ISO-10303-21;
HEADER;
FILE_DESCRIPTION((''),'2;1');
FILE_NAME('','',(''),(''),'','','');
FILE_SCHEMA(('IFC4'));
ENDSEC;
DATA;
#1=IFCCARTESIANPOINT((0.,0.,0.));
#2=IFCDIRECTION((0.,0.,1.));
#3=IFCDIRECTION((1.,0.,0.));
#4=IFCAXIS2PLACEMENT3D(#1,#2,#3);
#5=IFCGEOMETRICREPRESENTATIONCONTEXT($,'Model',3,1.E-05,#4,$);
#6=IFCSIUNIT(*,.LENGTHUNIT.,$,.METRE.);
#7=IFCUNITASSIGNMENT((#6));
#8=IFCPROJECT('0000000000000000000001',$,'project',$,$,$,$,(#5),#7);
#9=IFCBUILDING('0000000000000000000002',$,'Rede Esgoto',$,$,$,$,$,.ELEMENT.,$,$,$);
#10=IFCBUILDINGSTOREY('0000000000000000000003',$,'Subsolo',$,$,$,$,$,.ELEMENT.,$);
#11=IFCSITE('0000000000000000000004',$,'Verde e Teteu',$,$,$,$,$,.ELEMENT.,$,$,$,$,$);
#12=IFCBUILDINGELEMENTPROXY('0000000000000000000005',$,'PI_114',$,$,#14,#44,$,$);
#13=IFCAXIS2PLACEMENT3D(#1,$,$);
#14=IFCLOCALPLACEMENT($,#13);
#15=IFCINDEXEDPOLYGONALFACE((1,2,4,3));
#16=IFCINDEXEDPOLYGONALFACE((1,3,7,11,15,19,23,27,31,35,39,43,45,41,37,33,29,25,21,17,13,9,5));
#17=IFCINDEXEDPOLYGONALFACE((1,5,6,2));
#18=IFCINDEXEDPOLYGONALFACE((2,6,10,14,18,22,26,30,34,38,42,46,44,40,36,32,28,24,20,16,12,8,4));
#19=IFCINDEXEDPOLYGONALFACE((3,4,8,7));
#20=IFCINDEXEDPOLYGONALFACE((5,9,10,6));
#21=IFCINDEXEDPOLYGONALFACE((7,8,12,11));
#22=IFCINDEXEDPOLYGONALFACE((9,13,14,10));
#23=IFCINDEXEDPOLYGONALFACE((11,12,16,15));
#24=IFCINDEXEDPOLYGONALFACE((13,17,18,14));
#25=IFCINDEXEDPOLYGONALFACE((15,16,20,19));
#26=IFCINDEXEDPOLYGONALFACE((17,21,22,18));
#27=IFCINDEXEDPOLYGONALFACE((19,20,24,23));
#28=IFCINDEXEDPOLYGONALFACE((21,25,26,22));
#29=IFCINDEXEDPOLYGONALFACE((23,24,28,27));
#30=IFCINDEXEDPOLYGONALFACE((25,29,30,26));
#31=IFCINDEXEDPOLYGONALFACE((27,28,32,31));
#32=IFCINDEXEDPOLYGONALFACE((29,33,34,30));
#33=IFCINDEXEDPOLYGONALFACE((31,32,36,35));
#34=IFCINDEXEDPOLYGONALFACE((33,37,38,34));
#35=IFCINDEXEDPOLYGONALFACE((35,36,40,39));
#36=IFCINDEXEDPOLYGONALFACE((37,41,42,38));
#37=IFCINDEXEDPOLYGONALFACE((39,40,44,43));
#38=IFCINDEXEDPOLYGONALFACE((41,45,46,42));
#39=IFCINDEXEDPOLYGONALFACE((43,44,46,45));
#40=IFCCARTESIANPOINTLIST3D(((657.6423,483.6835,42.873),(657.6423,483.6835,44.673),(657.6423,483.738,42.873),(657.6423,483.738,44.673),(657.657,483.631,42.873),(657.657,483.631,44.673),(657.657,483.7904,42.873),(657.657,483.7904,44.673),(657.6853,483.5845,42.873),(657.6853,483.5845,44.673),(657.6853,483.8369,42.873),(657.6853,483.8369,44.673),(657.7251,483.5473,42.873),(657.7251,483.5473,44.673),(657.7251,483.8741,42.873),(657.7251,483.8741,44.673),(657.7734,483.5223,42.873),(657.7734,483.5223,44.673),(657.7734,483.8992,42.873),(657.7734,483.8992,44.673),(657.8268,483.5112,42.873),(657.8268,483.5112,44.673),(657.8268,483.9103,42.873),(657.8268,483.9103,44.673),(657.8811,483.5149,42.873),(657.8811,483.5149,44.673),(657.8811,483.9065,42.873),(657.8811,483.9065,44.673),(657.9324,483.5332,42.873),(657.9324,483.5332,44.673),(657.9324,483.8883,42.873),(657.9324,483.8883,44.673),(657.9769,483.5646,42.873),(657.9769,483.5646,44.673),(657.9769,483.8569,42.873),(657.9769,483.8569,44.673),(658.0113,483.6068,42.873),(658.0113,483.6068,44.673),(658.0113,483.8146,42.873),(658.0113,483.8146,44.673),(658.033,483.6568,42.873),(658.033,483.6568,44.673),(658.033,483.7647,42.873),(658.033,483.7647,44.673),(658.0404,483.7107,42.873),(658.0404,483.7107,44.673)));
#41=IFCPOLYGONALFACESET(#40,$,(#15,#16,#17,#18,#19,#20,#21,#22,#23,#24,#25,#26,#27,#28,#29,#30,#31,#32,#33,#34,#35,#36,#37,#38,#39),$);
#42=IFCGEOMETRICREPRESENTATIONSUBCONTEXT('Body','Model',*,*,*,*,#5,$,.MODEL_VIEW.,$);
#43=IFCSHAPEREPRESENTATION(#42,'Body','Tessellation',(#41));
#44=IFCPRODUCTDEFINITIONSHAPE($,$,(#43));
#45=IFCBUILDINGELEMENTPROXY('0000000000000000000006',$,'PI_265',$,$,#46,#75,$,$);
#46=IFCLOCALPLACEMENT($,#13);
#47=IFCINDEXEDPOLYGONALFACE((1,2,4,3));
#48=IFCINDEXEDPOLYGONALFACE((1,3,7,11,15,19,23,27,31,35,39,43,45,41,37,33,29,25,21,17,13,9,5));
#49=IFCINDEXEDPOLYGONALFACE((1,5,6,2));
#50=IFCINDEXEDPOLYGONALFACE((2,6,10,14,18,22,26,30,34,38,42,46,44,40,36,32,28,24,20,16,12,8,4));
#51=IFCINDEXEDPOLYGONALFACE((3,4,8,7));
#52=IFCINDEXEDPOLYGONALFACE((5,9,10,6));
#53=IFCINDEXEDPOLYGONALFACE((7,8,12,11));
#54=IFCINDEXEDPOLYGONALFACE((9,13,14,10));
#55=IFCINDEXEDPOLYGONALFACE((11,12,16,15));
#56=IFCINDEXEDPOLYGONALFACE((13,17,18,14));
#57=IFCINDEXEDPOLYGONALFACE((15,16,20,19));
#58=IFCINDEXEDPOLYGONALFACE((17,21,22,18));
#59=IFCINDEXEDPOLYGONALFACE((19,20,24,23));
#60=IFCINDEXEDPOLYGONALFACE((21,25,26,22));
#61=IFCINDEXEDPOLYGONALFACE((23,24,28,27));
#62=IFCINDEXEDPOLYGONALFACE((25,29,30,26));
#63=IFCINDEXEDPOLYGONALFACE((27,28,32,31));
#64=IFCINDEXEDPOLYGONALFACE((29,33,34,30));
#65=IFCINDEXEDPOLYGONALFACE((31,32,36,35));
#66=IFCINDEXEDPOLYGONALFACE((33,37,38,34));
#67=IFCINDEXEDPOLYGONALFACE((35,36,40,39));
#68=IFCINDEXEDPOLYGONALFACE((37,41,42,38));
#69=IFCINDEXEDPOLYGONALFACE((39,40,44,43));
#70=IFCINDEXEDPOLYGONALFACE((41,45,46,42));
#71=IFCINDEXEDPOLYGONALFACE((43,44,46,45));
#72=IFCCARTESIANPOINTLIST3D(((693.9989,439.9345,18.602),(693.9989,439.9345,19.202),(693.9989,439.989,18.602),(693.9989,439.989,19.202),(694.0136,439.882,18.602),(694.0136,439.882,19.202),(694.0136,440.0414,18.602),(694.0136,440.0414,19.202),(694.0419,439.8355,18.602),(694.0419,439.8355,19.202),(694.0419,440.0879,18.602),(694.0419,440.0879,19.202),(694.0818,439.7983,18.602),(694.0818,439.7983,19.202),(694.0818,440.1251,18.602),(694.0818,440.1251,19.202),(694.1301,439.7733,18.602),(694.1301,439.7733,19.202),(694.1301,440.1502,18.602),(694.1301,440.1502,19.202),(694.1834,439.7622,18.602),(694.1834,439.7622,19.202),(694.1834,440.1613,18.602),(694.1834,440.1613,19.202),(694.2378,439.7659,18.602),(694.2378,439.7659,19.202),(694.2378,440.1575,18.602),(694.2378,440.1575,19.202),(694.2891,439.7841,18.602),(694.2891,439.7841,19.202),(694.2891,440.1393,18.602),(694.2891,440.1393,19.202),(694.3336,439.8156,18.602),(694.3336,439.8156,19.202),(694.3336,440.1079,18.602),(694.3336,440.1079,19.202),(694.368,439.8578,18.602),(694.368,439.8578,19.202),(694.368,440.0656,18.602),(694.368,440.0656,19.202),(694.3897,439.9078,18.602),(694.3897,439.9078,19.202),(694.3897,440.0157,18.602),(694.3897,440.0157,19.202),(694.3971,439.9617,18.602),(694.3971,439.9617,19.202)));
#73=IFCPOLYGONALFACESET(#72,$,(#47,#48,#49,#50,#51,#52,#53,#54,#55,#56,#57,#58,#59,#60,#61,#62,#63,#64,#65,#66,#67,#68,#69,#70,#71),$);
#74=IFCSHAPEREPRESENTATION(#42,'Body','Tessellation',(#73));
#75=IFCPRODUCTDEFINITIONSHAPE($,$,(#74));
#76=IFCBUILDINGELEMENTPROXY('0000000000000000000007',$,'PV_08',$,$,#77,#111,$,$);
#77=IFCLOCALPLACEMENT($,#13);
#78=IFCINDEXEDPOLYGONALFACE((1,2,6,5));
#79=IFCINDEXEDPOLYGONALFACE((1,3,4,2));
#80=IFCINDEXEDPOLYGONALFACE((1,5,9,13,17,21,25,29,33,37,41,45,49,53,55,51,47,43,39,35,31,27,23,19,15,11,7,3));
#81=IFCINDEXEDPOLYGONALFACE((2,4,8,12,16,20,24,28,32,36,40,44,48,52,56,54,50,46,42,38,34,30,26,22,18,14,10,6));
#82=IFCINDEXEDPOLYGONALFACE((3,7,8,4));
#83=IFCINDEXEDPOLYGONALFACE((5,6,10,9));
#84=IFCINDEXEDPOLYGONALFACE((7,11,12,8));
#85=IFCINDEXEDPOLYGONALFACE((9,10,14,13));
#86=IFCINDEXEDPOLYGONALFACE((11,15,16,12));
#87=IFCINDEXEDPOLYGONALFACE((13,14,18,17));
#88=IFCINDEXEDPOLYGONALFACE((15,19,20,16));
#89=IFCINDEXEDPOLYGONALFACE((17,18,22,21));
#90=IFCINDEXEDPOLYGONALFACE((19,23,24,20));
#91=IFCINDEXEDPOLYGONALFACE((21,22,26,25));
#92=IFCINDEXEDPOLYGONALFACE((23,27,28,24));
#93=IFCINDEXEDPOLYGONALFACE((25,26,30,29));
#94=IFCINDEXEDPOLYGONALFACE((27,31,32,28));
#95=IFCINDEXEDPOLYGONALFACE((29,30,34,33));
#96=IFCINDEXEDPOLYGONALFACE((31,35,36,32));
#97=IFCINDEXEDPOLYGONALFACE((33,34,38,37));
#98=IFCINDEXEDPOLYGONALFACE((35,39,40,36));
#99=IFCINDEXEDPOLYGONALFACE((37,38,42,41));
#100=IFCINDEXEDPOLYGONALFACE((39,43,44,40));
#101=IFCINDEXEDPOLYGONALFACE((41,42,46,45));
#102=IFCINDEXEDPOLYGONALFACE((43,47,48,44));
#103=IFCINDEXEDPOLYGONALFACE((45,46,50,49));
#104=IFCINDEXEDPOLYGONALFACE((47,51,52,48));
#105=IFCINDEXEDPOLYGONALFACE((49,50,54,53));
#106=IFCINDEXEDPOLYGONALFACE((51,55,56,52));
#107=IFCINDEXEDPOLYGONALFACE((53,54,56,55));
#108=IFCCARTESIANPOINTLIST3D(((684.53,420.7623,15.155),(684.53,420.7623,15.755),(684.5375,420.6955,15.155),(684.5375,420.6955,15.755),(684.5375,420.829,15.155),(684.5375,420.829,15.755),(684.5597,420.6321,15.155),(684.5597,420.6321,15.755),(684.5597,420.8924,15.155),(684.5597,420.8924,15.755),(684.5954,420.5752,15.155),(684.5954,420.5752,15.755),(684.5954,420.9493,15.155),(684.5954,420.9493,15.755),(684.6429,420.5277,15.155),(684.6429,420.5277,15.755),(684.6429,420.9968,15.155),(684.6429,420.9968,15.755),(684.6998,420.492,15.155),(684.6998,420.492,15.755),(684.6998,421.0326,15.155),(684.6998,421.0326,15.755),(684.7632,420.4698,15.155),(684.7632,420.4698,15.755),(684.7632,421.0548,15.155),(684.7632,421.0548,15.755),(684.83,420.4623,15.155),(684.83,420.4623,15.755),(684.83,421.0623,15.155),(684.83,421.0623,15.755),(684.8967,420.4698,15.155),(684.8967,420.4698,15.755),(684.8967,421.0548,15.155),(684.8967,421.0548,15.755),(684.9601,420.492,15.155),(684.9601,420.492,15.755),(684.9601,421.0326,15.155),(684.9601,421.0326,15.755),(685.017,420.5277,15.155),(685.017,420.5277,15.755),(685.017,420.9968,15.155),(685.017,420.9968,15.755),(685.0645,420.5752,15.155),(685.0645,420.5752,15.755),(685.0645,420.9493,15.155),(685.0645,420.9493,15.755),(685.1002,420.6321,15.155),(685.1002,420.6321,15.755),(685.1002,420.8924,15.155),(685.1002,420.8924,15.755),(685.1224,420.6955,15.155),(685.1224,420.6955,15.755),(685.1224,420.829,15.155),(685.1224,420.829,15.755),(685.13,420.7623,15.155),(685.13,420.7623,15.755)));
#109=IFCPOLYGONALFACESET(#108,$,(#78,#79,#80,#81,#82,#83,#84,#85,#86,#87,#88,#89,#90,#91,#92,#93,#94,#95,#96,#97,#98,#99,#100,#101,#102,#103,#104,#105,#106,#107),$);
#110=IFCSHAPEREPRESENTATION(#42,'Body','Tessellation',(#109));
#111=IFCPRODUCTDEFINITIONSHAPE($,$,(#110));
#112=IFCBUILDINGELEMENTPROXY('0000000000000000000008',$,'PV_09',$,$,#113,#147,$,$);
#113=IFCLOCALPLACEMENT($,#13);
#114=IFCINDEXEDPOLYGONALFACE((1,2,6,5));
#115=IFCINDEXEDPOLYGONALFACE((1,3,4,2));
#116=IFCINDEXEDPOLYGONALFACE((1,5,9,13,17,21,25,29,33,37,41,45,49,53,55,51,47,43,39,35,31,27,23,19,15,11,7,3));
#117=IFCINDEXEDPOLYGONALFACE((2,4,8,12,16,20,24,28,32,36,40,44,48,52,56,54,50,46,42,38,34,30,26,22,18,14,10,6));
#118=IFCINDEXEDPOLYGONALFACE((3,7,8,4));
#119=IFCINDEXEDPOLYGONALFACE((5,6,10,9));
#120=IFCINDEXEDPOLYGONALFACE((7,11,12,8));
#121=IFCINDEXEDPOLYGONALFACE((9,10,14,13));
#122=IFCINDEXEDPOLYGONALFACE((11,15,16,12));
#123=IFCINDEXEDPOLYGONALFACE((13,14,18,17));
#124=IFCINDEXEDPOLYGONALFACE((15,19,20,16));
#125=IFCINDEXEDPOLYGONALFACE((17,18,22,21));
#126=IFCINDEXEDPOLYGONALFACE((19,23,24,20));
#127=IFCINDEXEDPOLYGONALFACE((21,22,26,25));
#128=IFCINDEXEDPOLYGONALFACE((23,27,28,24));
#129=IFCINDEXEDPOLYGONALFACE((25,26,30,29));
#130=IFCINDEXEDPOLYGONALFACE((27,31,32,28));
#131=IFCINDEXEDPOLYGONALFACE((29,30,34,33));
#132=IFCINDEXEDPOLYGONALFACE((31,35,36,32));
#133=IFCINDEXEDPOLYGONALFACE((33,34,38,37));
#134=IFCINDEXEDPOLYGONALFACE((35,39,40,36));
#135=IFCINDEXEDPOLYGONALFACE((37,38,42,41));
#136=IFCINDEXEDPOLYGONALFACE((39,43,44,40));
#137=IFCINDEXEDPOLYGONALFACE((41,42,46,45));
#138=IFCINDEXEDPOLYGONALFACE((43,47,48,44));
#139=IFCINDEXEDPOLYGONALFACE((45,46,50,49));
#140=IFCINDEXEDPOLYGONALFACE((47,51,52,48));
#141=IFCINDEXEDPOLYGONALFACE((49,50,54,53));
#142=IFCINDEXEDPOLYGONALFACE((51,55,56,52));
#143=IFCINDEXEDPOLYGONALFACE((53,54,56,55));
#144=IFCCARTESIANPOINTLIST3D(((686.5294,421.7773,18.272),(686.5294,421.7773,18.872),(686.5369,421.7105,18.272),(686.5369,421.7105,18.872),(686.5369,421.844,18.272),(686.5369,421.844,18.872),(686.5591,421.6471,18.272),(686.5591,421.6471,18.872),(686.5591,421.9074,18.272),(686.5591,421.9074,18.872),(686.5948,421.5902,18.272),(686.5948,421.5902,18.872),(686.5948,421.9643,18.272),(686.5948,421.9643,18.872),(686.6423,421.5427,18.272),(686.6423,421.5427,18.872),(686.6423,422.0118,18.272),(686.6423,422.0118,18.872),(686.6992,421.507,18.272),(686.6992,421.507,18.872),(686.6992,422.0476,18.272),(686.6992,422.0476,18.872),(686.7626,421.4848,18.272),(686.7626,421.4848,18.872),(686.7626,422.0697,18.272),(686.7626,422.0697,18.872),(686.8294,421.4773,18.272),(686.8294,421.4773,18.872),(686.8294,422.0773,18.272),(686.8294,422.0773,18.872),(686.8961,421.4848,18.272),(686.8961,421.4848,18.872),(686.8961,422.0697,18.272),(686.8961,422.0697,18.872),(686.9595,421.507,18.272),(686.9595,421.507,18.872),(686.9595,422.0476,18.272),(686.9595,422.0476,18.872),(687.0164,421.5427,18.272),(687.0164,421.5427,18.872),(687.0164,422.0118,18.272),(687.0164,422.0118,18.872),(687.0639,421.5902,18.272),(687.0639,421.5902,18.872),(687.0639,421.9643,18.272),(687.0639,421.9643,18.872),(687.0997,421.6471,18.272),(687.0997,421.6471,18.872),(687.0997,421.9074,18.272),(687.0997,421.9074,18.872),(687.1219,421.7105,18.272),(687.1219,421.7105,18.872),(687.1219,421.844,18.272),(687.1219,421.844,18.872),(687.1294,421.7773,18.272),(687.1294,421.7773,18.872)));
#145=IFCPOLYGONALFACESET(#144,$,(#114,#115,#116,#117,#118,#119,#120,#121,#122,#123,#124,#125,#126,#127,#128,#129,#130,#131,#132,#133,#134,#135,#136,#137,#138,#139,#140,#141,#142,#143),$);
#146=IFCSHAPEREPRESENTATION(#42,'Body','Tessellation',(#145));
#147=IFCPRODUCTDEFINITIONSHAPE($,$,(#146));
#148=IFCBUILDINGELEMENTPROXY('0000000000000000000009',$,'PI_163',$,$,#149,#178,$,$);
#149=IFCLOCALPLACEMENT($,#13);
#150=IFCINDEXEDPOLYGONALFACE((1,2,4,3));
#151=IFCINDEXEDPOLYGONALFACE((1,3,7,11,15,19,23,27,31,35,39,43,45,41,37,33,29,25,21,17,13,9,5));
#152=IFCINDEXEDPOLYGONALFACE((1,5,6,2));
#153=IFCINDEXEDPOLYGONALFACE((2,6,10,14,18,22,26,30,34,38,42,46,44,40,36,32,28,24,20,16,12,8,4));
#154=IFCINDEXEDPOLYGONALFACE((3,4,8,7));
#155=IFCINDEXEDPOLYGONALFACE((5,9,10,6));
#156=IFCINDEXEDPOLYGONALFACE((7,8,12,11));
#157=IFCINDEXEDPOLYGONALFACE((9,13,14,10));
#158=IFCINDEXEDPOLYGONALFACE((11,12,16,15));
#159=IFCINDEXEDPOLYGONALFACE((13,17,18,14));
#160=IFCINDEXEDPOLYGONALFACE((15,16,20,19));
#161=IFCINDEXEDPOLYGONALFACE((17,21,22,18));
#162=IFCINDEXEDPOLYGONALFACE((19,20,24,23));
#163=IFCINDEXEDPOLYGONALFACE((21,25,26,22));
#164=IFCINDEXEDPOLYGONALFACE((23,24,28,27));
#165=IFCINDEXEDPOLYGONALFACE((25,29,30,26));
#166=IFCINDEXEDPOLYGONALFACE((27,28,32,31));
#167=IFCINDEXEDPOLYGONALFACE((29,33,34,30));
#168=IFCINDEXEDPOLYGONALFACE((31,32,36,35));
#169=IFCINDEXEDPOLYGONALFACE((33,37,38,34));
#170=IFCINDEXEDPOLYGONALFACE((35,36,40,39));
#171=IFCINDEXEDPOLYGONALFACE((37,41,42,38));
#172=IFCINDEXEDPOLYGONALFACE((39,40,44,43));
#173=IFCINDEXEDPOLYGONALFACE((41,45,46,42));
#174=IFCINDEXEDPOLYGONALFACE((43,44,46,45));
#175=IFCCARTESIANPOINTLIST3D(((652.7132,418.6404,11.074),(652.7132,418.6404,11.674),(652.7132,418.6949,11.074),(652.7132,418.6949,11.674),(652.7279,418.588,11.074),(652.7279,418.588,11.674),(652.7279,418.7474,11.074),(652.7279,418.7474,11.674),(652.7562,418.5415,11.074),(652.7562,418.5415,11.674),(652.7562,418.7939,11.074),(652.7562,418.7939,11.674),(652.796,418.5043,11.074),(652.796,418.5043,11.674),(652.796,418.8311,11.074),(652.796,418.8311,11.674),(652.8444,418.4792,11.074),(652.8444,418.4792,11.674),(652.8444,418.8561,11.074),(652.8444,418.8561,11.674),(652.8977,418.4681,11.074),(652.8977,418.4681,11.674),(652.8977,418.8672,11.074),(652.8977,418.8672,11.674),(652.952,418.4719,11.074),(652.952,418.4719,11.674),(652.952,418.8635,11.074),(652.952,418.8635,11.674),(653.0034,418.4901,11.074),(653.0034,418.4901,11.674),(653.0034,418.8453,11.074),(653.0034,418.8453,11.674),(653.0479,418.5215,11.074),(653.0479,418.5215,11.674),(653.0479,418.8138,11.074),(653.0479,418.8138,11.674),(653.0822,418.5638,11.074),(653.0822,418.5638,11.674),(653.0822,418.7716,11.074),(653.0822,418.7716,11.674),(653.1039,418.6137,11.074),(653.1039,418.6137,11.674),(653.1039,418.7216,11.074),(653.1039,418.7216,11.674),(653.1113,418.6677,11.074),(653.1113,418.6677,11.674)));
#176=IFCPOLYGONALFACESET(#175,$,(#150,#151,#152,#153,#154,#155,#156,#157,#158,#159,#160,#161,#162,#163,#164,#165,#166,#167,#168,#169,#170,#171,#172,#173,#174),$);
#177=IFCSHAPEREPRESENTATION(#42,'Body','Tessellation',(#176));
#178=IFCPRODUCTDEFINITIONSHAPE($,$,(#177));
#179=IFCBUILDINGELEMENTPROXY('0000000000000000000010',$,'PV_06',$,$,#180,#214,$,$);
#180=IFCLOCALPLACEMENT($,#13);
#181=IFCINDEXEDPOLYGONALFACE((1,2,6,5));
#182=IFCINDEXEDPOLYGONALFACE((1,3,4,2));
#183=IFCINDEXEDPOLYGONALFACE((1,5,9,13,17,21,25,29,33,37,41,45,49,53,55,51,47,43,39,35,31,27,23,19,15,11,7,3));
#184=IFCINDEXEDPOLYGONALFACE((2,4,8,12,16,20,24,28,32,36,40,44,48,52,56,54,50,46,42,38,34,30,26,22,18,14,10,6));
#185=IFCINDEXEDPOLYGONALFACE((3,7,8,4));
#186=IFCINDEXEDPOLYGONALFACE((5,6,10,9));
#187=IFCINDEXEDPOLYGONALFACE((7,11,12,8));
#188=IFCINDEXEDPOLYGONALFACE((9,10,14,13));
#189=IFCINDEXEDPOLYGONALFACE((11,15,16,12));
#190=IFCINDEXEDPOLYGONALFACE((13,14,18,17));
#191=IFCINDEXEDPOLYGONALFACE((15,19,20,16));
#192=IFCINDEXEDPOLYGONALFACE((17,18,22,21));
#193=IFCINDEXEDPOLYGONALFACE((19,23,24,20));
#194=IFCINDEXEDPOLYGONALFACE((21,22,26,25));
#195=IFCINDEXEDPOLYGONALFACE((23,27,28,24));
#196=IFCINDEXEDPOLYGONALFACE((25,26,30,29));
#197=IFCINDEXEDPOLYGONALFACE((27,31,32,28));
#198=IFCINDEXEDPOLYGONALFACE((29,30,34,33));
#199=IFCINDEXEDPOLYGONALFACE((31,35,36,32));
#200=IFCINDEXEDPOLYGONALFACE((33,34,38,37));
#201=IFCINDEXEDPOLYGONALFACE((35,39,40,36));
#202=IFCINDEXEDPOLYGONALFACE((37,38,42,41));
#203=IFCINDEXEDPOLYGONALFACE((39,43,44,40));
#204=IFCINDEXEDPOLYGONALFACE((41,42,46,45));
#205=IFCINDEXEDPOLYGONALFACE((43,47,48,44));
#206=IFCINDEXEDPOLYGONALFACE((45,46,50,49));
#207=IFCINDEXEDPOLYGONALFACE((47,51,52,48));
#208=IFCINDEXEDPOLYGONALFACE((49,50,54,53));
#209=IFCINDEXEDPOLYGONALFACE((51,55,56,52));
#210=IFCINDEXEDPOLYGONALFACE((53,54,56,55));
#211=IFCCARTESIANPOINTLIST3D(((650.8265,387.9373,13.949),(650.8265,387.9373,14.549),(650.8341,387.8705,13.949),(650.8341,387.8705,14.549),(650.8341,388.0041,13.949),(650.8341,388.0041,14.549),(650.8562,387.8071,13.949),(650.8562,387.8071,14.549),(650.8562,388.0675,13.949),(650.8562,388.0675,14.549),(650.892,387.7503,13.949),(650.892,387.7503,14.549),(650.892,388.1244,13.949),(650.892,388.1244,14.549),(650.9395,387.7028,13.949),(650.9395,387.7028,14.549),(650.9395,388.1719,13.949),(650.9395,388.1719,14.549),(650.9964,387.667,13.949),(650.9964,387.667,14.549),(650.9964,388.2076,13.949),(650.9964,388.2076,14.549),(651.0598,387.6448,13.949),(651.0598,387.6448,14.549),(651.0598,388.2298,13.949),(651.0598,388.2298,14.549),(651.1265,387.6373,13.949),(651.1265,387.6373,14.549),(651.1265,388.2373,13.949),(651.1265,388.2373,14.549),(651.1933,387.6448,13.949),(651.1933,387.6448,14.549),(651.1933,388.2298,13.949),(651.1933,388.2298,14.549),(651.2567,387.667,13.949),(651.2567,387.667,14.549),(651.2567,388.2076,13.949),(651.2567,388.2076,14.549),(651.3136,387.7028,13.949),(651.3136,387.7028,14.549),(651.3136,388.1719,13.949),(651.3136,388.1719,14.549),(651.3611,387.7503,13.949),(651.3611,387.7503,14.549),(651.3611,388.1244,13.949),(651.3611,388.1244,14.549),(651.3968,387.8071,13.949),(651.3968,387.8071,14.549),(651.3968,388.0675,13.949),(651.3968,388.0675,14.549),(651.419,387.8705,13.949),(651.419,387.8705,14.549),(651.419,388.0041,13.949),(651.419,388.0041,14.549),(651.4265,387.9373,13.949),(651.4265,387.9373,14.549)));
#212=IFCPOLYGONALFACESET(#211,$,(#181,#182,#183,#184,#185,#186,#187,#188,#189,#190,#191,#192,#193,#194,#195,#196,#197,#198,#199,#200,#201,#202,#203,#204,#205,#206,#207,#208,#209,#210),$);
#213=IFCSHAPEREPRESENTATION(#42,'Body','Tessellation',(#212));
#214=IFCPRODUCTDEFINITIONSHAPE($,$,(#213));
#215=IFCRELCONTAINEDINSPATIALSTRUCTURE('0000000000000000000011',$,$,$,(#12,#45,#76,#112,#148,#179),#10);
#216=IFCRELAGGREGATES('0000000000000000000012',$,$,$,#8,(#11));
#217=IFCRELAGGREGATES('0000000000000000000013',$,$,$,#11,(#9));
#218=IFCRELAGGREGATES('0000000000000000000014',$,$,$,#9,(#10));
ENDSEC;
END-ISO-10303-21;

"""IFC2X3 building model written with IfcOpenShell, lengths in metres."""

from ifc_helpers import new_model, si_unit, frame, origin_with_axes, origin_2d, place, context, subcontext, project, spatial, circle, extrude, element, save


model = new_model("IFC2X3")

# Units and contexts
model_context = context("Model", 3, precision=1e-05, world=origin_with_axes())
body_context = subcontext(model_context, "Body", "Model", "MODEL_VIEW")
ifc_project = project(units=[si_unit("LENGTHUNIT", "METRE")], contexts=[model_context])

# Site, building, storey
site = spatial("IfcSite", under=ifc_project, Name="Verde e Teteu", CompositionType="ELEMENT")
building = spatial("IfcBuilding", under=site, Name="Rede Esgoto", CompositionType="ELEMENT")
storey = spatial("IfcBuildingStorey", under=building, Name="Subsolo", CompositionType="ELEMENT")

# Building element proxies
proxy_1_placement = place(None, frame((657.8404, 483.7107, 42.873), z_axis=(0.0, 0.0, 1.0), x_axis=(1.0, 0.0, 0.0)))
element("IfcBuildingElementProxy", 1, at=proxy_1_placement, inside=storey, Name="PI_114", context=body_context, shape_type="SweptSolid", body=[
    extrude(circle(Radius=0.2, at=origin_2d()), origin_with_axes(), (0.0, 0.0, 1.0), 1.8),
])
proxy_2_placement = place(None, frame((694.1971, 439.9617, 18.602), z_axis=(0.0, 0.0, 1.0), x_axis=(1.0, 0.0, 0.0)))
element("IfcBuildingElementProxy", 2, at=proxy_2_placement, inside=storey, Name="PI_265", context=body_context, shape_type="SweptSolid", body=[
    extrude(circle(Radius=0.2, at=origin_2d()), origin_with_axes(), (0.0, 0.0, 1.0), 0.6),
])
for number, where, z_axis, x_axis, name in (
    (3, (684.83, 420.7623, 15.155), (0.0, 0.0, 1.0), (1.0, 0.0, 0.0), "PV_08"),
    (4, (686.8294, 421.7773, 18.272), (0.0, 0.0, 1.0), (1.0, 0.0, 0.0), "PV_09"),
):
    element("IfcBuildingElementProxy", number, at=place(None, frame(where, z_axis=z_axis, x_axis=x_axis)), inside=storey, Name=name, context=body_context, shape_type="SweptSolid", body=[
        extrude(circle(Radius=0.3, at=origin_2d()), origin_with_axes(), (0.0, 0.0, 1.0), 0.6),
    ])
proxy_3_placement = place(None, frame((652.9113, 418.6677, 11.074), z_axis=(0.0, 0.0, 1.0), x_axis=(1.0, 0.0, 0.0)))
element("IfcBuildingElementProxy", 5, at=proxy_3_placement, inside=storey, Name="PI_163", context=body_context, shape_type="SweptSolid", body=[
    extrude(circle(Radius=0.2, at=origin_2d()), origin_with_axes(), (0.0, 0.0, 1.0), 0.6),
])
proxy_4_placement = place(None, frame((651.1265, 387.9373, 13.949), z_axis=(0.0, 0.0, 1.0), x_axis=(1.0, 0.0, 0.0)))
element("IfcBuildingElementProxy", 6, at=proxy_4_placement, inside=storey, Name="PV_06", context=body_context, shape_type="SweptSolid", body=[
    extrude(circle(Radius=0.3, at=origin_2d()), origin_with_axes(), (0.0, 0.0, 1.0), 0.6),
])

save(model, "model.ifc")
